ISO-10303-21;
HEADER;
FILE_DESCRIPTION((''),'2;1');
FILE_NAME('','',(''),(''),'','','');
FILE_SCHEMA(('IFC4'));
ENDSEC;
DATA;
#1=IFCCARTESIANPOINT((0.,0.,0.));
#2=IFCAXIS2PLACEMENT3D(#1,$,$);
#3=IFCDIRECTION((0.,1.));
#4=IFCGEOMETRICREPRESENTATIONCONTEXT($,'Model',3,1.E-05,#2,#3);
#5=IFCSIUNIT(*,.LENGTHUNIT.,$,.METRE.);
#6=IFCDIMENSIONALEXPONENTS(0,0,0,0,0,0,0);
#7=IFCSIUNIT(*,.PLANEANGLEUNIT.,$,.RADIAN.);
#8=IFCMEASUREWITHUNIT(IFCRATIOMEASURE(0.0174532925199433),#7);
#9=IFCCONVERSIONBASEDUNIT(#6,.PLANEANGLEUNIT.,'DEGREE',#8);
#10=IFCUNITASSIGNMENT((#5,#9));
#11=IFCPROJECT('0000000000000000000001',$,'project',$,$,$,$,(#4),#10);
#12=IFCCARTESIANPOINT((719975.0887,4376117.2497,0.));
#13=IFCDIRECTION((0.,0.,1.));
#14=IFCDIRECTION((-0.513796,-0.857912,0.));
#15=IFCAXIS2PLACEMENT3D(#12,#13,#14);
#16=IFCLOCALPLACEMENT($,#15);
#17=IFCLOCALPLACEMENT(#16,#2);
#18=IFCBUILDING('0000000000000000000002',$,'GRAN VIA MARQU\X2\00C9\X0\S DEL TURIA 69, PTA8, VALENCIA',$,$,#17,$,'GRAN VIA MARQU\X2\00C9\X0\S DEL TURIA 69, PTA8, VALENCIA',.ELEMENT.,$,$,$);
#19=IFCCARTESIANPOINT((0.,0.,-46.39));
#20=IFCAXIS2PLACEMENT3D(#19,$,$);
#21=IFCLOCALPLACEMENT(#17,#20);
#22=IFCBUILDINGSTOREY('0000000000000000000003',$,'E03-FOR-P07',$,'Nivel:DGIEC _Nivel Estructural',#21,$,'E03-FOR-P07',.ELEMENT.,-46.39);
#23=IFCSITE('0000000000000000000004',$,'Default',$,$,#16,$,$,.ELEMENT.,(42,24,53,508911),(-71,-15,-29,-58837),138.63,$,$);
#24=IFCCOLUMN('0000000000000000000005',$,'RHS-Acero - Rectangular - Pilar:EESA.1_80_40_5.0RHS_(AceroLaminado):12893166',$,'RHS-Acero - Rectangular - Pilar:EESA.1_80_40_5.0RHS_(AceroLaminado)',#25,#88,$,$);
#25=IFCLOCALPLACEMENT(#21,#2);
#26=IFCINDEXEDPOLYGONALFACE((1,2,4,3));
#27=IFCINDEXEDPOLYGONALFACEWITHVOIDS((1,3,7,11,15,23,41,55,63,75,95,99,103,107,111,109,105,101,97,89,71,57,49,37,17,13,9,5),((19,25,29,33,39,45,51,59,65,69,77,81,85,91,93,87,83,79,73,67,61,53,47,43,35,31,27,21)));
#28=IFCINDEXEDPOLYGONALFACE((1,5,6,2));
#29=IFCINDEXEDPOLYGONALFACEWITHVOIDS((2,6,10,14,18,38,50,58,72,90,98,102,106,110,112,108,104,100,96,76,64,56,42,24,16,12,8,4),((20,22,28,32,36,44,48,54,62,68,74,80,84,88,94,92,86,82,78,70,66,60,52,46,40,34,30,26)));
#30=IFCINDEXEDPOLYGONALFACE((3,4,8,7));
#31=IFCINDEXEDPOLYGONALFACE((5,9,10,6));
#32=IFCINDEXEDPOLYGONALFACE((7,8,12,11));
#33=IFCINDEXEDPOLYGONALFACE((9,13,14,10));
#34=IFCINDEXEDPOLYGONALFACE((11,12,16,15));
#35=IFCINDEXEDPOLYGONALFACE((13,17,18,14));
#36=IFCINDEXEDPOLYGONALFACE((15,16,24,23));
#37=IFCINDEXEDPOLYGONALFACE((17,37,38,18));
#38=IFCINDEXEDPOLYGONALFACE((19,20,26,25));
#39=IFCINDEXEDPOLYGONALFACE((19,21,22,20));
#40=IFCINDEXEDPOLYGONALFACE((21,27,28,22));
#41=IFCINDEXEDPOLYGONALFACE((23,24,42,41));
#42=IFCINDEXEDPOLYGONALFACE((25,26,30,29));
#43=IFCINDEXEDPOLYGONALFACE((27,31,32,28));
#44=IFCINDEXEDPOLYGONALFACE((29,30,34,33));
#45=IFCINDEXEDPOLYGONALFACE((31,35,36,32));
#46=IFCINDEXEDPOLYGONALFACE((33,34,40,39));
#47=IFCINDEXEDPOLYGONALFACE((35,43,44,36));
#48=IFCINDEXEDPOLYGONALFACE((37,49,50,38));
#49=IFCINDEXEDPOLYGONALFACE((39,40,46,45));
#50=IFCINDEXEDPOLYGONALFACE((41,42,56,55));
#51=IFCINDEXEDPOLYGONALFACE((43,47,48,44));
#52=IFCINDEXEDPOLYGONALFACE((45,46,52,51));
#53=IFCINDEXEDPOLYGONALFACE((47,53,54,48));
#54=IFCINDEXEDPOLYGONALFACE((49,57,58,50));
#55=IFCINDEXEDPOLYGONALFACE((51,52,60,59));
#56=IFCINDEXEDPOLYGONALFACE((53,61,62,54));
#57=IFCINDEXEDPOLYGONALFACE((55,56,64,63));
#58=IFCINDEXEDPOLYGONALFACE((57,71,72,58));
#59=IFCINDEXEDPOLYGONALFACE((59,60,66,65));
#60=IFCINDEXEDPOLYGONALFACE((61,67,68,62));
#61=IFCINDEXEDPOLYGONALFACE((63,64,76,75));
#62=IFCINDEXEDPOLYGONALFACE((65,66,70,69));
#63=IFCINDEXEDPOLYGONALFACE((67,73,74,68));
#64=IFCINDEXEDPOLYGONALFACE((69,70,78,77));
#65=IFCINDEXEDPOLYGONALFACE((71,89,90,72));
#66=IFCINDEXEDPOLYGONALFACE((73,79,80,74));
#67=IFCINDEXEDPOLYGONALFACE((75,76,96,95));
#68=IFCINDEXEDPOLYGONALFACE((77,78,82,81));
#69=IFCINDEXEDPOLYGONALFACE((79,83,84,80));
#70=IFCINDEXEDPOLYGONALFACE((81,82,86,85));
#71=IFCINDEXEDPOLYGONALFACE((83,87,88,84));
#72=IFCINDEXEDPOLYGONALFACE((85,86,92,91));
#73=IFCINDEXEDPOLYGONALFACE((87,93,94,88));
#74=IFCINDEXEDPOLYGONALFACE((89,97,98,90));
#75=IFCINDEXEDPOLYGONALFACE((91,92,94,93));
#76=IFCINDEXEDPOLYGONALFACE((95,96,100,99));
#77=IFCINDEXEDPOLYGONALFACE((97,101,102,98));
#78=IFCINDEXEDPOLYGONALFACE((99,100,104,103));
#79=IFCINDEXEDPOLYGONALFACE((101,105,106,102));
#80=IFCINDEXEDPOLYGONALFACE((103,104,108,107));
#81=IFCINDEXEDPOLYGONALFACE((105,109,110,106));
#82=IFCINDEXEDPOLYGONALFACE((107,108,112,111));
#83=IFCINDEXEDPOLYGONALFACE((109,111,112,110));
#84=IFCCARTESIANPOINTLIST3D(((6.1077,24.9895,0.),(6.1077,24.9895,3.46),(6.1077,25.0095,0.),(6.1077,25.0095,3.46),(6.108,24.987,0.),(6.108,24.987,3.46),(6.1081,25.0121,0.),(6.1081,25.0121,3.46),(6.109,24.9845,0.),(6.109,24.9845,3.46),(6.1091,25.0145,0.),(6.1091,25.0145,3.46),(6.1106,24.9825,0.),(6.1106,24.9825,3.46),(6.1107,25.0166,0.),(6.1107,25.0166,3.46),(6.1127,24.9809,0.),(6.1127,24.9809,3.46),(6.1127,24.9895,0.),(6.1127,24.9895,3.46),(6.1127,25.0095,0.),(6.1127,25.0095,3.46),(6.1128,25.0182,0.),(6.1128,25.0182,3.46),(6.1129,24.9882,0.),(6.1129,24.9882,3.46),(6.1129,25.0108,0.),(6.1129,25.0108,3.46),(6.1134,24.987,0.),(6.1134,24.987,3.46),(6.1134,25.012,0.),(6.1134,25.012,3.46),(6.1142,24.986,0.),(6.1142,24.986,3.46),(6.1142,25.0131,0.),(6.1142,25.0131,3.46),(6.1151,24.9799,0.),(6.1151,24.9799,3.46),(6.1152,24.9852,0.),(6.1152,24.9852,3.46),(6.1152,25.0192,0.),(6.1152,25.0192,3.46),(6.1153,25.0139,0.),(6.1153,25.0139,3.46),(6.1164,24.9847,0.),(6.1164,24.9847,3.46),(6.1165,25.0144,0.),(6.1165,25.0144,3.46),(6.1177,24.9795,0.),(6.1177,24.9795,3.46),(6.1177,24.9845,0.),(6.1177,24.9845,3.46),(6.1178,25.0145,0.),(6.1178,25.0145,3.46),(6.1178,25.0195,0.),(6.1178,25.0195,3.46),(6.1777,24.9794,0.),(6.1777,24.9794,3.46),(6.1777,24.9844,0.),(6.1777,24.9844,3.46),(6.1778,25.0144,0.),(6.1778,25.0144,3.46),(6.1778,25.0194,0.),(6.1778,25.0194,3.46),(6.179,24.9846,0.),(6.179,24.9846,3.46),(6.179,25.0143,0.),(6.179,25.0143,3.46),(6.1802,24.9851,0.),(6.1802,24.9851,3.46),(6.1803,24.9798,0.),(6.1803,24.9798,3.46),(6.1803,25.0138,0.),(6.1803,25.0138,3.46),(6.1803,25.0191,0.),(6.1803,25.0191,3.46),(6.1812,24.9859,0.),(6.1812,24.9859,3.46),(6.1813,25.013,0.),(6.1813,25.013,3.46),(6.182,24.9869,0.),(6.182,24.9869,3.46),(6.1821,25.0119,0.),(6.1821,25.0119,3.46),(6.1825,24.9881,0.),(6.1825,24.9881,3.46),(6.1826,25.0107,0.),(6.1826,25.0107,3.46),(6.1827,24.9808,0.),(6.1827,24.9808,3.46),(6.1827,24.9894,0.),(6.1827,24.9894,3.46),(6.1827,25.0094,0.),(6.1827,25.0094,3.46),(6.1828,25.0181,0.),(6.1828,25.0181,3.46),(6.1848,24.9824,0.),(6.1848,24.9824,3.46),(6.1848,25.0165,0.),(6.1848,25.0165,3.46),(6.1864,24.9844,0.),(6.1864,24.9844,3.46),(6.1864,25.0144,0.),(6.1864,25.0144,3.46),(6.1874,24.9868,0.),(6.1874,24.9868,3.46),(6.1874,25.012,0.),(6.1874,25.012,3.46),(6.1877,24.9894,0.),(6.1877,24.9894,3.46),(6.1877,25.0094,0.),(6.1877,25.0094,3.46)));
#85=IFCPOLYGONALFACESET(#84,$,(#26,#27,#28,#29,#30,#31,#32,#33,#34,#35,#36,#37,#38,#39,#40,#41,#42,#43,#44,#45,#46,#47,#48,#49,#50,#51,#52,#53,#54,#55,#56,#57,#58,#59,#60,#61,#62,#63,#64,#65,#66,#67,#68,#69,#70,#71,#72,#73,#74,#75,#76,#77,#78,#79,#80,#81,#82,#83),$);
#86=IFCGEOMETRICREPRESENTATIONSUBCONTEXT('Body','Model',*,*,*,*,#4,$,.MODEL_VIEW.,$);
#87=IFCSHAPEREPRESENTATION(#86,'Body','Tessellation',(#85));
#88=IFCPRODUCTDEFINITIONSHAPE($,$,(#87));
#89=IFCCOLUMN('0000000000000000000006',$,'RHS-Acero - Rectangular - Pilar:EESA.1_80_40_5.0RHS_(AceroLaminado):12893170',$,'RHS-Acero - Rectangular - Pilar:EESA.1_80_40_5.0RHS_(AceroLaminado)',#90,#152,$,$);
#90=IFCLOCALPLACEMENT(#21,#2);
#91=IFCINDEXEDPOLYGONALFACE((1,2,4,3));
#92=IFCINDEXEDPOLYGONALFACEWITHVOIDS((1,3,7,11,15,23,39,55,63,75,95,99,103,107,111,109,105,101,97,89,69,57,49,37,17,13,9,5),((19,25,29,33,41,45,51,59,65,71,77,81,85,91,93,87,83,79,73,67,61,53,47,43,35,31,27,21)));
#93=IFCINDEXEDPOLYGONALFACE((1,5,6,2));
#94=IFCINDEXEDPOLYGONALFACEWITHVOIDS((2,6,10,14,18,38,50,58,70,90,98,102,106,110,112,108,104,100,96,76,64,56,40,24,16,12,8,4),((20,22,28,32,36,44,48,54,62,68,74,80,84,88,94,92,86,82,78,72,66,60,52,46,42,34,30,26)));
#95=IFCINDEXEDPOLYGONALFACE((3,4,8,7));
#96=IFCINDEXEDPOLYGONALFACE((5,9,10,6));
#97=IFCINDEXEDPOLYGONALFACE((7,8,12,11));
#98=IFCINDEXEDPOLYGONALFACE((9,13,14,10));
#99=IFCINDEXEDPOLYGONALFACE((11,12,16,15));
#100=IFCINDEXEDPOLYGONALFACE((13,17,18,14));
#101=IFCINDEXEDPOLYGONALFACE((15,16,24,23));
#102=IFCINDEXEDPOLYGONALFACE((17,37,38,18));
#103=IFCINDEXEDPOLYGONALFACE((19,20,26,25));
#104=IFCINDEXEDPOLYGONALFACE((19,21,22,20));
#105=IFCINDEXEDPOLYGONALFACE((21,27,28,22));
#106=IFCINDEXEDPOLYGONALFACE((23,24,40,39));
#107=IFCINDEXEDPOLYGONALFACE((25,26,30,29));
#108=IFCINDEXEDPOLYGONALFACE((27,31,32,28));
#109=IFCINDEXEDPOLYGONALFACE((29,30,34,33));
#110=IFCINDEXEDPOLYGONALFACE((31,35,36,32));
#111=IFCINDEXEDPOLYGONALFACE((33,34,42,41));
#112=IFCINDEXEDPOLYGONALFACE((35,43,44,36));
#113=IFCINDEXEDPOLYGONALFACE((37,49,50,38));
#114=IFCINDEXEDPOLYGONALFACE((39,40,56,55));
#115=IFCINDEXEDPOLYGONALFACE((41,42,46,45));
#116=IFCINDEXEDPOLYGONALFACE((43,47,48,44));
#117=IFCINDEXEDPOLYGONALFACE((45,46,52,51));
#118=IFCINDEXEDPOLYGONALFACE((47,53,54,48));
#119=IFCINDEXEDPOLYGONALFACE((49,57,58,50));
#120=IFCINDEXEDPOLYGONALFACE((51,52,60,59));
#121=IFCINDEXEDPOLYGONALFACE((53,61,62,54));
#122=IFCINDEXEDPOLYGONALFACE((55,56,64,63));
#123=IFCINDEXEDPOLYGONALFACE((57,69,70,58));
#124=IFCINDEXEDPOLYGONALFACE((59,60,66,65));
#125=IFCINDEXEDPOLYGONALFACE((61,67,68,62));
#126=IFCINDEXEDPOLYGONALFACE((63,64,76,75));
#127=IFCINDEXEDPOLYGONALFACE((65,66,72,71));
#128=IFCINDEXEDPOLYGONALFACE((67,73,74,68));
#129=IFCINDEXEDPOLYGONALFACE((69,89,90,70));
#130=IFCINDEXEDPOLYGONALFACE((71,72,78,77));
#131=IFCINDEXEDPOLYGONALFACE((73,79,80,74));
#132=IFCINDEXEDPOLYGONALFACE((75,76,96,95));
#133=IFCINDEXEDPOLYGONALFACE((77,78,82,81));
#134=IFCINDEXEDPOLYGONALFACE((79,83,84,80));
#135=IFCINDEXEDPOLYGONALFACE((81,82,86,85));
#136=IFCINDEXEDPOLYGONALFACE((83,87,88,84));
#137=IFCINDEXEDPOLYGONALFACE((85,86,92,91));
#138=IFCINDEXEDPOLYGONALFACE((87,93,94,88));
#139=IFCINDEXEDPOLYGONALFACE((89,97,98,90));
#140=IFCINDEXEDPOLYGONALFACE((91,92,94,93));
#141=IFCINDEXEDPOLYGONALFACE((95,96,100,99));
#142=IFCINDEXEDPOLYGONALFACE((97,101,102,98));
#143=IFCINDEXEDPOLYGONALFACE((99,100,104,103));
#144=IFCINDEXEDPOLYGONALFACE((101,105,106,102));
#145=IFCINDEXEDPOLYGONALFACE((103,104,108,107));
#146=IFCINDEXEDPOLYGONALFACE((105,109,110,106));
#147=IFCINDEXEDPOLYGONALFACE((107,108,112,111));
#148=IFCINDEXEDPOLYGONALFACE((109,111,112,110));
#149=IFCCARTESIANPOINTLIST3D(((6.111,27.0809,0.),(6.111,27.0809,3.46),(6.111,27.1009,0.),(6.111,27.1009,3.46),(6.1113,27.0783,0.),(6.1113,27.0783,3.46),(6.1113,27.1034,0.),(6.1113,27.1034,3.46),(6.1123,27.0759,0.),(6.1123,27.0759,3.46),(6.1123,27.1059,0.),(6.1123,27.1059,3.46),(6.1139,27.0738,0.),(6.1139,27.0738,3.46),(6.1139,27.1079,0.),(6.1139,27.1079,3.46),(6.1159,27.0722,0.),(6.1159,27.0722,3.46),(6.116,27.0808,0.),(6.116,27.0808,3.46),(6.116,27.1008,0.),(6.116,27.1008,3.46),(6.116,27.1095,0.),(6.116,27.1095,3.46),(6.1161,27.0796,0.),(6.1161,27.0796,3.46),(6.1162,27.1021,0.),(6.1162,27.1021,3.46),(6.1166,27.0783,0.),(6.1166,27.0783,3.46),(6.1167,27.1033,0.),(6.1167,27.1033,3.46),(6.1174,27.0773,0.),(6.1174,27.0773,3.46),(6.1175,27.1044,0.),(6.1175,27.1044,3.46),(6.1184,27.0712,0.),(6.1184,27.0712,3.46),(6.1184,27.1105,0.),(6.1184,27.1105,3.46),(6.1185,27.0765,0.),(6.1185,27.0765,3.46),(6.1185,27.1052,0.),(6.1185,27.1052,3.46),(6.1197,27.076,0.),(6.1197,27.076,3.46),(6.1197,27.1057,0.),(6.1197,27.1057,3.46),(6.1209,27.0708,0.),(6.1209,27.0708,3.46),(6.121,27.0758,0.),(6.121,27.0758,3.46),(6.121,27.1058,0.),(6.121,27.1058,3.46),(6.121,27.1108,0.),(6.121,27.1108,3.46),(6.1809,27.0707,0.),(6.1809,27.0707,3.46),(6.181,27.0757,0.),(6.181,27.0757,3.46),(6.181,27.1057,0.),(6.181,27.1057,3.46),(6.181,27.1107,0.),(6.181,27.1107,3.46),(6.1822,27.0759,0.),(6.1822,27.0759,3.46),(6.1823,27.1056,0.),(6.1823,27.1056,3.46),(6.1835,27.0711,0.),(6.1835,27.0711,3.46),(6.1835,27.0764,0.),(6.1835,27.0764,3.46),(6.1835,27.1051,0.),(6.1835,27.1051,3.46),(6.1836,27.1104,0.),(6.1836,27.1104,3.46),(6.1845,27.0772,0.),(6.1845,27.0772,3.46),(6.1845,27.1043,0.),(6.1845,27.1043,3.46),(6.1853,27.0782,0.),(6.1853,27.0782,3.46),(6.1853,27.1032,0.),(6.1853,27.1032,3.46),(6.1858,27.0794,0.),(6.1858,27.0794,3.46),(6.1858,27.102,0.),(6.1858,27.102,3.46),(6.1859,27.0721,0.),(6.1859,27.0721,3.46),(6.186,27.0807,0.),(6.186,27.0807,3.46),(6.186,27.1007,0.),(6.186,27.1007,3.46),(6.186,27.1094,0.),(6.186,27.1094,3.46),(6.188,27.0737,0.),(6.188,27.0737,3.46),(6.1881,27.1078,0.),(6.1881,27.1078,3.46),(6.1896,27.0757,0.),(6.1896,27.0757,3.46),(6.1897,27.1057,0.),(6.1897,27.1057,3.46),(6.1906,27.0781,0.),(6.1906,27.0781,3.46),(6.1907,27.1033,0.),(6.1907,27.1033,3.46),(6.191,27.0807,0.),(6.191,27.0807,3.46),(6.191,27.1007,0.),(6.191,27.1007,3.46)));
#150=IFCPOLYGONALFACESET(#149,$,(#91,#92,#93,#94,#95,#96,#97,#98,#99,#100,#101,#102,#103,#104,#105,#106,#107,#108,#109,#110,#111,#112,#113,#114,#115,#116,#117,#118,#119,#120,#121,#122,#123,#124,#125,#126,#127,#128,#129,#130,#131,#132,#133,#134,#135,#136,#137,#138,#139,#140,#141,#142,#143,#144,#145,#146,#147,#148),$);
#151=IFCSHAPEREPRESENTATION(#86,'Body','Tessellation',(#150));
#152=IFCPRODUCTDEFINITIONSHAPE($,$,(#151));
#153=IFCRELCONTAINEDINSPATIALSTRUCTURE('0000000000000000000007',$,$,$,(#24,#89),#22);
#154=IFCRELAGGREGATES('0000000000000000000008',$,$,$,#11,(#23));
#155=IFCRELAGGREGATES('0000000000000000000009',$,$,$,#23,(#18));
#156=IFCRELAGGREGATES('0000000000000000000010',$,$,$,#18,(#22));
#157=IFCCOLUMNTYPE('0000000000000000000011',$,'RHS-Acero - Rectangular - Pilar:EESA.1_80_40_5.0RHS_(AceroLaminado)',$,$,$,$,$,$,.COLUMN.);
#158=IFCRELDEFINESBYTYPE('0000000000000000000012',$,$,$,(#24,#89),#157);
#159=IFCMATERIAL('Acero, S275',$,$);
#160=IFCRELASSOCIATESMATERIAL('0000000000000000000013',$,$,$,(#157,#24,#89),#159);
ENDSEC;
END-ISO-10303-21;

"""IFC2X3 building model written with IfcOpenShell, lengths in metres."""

from ifc_helpers import new_model, entity, si_unit, converted_unit, direction, frame, frame_2d, origin, place, context, subcontext, project, spatial, polyline, circle_curve, parameter, trimmed, segment, composite_curve, outline, extrude, source, transform, mapped, material, type_object, type_shapes, element, save


model = new_model("IFC2X3")

# Units and contexts
model_context = context("Model", 3, precision=1e-05, world=origin(), true_north=direction((0.0, 1.0)))
body_context = subcontext(model_context, "Body", "Model", "MODEL_VIEW")
ifc_project = project(units=[si_unit("LENGTHUNIT", "METRE"), converted_unit("PLANEANGLEUNIT", "DEGREE", entity("IfcRatioMeasure", 0.0174532925199433), si_unit("PLANEANGLEUNIT", "RADIAN"), dimensions=[0, 0, 0, 0, 0, 0, 0])], contexts=[model_context])

# Site, building, storey
site_placement = place(None, frame((719975.0887, 4376117.2497, 0.0), z_axis=(0.0, 0.0, 1.0), x_axis=(-0.513796, -0.857912, 0.0)))
site = spatial("IfcSite", under=ifc_project, at=site_placement, Name="Default", CompositionType="ELEMENT", RefLatitude=(42, 24, 53, 508911), RefLongitude=(-71, -15, -29, -58837), RefElevation=138.63)
building_placement = place(site_placement, origin())
building = spatial("IfcBuilding", under=site, at=building_placement, Name="GRAN VIA MARQUÉS DEL TURIA 69, PTA8, VALENCIA", LongName="GRAN VIA MARQUÉS DEL TURIA 69, PTA8, VALENCIA", CompositionType="ELEMENT")
storey_placement = place(building_placement, frame((0.0, 0.0, -46.39)))
storey = spatial("IfcBuildingStorey", under=building, at=storey_placement, Name="E03-FOR-P07", ObjectType="Nivel:DGIEC _Nivel Estructural", LongName="E03-FOR-P07", CompositionType="ELEMENT", Elevation=-46.39)

# Columns
ifc_material = material(Name="Acero, S275")
column_type_1 = type_object("IfcColumnType", Name="RHS-Acero - Rectangular - Pilar:EESA.1_80_40_5.0RHS_(AceroLaminado)", PredefinedType="COLUMN", material=ifc_material)
shared_shape_1 = source(origin(), body_context, "Body", "SweptSolid", [
    extrude(outline(composite_curve([segment(polyline([(-0.01, -0.04), (0.01, -0.04)]), True, "CONTINUOUS"), segment(trimmed(circle_curve(frame_2d((0.01, -0.03), x_axis=(-1.0, 0.0)), 0.01), [parameter(90.0)], [parameter(180.0)], True, "PARAMETER"), True, "CONTINUOUS"), segment(polyline([(0.02, -0.03), (0.02, 0.03)]), True, "CONTINUOUS"), segment(trimmed(circle_curve(frame_2d((0.01, 0.03), x_axis=(-1.0, 0.0)), 0.01), [parameter(180.0)], [parameter(270.0)], True, "PARAMETER"), True, "CONTINUOUS"), segment(polyline([(0.01, 0.04), (-0.01, 0.04)]), True, "CONTINUOUS"), segment(trimmed(circle_curve(frame_2d((-0.01, 0.03), x_axis=(-1.0, 0.0)), 0.01), [parameter(270.0)], [parameter(360.0)], True, "PARAMETER"), True, "CONTINUOUS"), segment(polyline([(-0.02, 0.03), (-0.02, -0.03)]), True, "CONTINUOUS"), segment(trimmed(circle_curve(frame_2d((-0.01, -0.03), x_axis=(-1.0, 0.0)), 0.01), [parameter(360.0)], [parameter(90.0)], True, "PARAMETER"), True, "CONTINUOUS")], self_intersect=False), holes=[composite_curve([segment(trimmed(circle_curve(frame_2d((-0.01, -0.03), x_axis=(-1.0, 0.0)), 0.005), [parameter(0.0)], [parameter(90.0)], True, "PARAMETER"), False, "CONTINUOUS"), segment(polyline([(-0.015, -0.03), (-0.015, 0.03)]), True, "CONTINUOUS"), segment(trimmed(circle_curve(frame_2d((-0.01, 0.03), x_axis=(-1.0, 0.0)), 0.005), [parameter(270.0)], [parameter(0.0)], True, "PARAMETER"), False, "CONTINUOUS"), segment(polyline([(-0.01, 0.035), (0.01, 0.035)]), True, "CONTINUOUS"), segment(trimmed(circle_curve(frame_2d((0.01, 0.03), x_axis=(-1.0, 0.0)), 0.005), [parameter(180.0)], [parameter(270.0)], True, "PARAMETER"), False, "CONTINUOUS"), segment(polyline([(0.015, 0.03), (0.015, -0.03)]), True, "CONTINUOUS"), segment(trimmed(circle_curve(frame_2d((0.01, -0.03), x_axis=(-1.0, 0.0)), 0.005), [parameter(90.0)], [parameter(180.0)], True, "PARAMETER"), False, "CONTINUOUS"), segment(polyline([(0.01, -0.035), (-0.01, -0.035)]), True, "CONTINUOUS")], self_intersect=False)]), frame((0.0, 0.0, -46.39), z_axis=(0.0, 0.0, 1.0), x_axis=(-1.0, 0.0, 0.0)), (0.0, 0.0, 1.0), 3.46),
])
type_shapes(column_type_1, [shared_shape_1])
for number, where, z_axis, x_axis, name in (
    (1, (6.1477, 24.9995, 46.39), (0.0, 0.0, 1.0), (0.001552, 0.999999, 0.0), "RHS-Acero - Rectangular - Pilar:EESA.1_80_40_5.0RHS_(AceroLaminado):12893166"),
    (2, (6.151, 27.0908, 46.39), (0.0, 0.0, 1.0), (0.001552, 0.999999, 0.0), "RHS-Acero - Rectangular - Pilar:EESA.1_80_40_5.0RHS_(AceroLaminado):12893170"),
):
    element("IfcColumn", number, at=place(storey_placement, frame(where, z_axis=z_axis, x_axis=x_axis)), inside=storey, type_object=column_type_1, material=ifc_material, Name=name, ObjectType="RHS-Acero - Rectangular - Pilar:EESA.1_80_40_5.0RHS_(AceroLaminado)", context=body_context, shape_type="MappedRepresentation", body=[
        mapped(shared_shape_1, transform((0.0, 0.0, 0.0), scale=1.0)),
    ])

save(model, "model.ifc")
